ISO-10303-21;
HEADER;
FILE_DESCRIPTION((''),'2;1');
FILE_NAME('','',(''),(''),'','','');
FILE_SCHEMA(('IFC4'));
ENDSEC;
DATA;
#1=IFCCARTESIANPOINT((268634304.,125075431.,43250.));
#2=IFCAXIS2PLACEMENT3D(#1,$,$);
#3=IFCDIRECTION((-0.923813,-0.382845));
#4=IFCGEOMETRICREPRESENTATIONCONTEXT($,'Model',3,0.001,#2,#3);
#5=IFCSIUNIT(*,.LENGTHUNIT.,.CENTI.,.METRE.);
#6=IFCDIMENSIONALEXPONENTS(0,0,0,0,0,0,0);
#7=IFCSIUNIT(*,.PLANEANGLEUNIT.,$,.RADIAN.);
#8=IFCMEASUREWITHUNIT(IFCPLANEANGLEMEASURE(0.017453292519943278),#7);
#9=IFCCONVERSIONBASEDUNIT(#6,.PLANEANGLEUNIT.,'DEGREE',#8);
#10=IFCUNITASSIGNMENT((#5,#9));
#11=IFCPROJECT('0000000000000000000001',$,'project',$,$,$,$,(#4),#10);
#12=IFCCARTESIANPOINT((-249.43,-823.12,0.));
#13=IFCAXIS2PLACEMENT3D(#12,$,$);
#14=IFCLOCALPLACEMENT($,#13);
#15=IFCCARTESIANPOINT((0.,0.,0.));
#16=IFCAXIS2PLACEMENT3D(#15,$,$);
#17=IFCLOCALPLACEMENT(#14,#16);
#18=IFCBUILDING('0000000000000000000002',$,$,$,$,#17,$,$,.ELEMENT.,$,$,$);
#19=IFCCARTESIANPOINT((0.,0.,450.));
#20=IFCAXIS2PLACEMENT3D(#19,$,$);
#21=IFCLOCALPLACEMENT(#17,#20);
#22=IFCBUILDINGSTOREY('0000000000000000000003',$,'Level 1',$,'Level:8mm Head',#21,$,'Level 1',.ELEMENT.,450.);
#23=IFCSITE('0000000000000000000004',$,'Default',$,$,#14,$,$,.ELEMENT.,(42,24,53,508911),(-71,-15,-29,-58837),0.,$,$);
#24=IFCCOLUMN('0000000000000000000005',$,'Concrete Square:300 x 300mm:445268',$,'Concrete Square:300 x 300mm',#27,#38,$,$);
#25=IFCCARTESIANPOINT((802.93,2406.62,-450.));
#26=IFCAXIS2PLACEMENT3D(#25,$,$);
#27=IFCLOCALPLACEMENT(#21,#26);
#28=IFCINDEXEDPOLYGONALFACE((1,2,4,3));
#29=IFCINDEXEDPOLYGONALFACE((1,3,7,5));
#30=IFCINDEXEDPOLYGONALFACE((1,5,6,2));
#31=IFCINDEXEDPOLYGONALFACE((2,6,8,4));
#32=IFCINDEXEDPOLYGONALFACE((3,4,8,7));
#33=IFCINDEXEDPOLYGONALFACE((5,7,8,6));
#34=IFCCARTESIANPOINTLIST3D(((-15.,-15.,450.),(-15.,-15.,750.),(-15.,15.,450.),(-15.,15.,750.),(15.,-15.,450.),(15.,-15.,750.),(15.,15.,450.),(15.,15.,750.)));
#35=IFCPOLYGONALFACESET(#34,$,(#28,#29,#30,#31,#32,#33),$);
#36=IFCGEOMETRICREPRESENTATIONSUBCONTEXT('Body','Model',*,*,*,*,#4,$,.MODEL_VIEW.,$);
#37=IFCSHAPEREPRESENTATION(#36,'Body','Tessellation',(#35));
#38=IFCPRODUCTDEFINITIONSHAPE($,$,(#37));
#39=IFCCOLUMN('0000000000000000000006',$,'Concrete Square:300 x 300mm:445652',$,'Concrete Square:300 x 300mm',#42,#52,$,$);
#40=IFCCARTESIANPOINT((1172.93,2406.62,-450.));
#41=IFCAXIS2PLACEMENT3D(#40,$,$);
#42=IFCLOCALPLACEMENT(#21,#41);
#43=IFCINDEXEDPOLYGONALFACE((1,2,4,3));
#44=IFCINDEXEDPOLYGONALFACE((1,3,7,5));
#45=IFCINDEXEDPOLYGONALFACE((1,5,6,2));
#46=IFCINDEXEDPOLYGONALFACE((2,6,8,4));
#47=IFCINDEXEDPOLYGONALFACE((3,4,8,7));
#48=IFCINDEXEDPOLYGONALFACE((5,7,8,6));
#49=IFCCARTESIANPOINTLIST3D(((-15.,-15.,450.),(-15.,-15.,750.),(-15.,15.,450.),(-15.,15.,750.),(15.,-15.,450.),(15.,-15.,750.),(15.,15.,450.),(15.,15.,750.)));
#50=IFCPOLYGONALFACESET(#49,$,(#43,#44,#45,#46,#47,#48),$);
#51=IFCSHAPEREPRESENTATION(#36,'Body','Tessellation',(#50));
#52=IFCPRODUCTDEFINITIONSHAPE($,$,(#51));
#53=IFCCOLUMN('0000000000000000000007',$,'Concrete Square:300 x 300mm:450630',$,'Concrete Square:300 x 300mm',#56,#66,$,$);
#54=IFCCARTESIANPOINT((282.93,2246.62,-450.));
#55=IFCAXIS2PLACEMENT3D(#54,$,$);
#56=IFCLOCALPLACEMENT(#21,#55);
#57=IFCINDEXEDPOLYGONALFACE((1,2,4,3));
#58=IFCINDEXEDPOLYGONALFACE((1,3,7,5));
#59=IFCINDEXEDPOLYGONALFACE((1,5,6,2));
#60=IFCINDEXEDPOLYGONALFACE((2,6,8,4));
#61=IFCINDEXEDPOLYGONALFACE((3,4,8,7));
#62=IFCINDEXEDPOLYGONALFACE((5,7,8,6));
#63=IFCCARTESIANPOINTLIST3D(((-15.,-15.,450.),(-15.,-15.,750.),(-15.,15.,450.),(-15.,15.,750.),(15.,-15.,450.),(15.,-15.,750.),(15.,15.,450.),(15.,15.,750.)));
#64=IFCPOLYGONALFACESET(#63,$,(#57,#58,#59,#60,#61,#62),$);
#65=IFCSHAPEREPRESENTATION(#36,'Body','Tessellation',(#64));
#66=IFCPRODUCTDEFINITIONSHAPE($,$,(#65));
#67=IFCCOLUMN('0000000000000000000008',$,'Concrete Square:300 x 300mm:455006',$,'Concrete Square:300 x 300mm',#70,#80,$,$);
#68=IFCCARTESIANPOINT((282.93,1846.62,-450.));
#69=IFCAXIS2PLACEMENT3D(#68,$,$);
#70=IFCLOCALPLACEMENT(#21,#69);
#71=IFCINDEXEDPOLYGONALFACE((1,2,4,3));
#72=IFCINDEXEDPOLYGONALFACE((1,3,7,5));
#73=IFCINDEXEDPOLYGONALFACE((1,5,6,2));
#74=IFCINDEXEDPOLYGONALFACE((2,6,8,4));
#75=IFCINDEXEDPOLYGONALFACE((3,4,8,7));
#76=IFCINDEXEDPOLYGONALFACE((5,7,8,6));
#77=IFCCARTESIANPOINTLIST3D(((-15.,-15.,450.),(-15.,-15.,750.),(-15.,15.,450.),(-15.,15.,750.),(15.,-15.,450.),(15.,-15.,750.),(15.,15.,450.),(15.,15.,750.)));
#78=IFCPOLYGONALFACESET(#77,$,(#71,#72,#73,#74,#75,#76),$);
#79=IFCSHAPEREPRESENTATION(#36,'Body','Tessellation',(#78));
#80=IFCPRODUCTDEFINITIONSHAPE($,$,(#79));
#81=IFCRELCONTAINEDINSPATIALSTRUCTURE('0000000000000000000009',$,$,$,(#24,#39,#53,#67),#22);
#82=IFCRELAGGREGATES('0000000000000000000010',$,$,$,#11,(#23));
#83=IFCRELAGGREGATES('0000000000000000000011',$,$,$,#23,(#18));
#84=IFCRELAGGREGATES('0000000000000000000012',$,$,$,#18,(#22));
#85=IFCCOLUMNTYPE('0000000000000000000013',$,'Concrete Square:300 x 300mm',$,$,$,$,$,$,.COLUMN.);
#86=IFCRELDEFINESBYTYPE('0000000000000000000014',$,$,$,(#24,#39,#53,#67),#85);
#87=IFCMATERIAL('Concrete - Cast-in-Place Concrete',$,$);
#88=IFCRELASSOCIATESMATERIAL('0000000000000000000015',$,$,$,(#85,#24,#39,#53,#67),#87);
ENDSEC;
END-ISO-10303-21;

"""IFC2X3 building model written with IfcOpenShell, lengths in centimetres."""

from ifc_helpers import new_model, entity, si_unit, converted_unit, direction, frame, origin, origin_2d_with_axis, place, context, subcontext, project, spatial, rectangle, extrude, source, transform, mapped, material, type_object, type_shapes, element, save


model = new_model("IFC2X3")

# Units and contexts
model_context = context("Model", 3, precision=0.001, world=frame((268634304.0, 125075431.0, 43250.0)), true_north=direction((-0.923813, -0.382845)))
body_context = subcontext(model_context, "Body", "Model", "MODEL_VIEW")
ifc_project = project(units=[si_unit("LENGTHUNIT", "METRE", prefix="CENTI"), converted_unit("PLANEANGLEUNIT", "DEGREE", entity("IfcPlaneAngleMeasure", 0.017453292519943278), si_unit("PLANEANGLEUNIT", "RADIAN"), dimensions=[0, 0, 0, 0, 0, 0, 0])], contexts=[model_context])

# Site, building, storey
site_placement = place(None, frame((-249.43, -823.12, 0.0)))
site = spatial("IfcSite", under=ifc_project, at=site_placement, Name="Default", CompositionType="ELEMENT", RefLatitude=(42, 24, 53, 508911), RefLongitude=(-71, -15, -29, -58837), RefElevation=0.0)
building_placement = place(site_placement, origin())
building = spatial("IfcBuilding", under=site, at=building_placement, CompositionType="ELEMENT")
storey_placement = place(building_placement, frame((0.0, 0.0, 450.0)))
storey = spatial("IfcBuildingStorey", under=building, at=storey_placement, Name="Level 1", ObjectType="Level:8mm Head", LongName="Level 1", CompositionType="ELEMENT", Elevation=450.0)

# Columns
ifc_material_1 = material(Name="Concrete - Cast-in-Place Concrete")
column_type = type_object("IfcColumnType", Name="Concrete Square:300 x 300mm", PredefinedType="COLUMN", material=ifc_material_1)
shared_shape_1 = source(origin(), body_context, "Body", "SweptSolid", [
    extrude(rectangle(XDim=30.0, YDim=30.0, at=origin_2d_with_axis()), frame((0.0, 0.0, 450.0), z_axis=(0.0, 0.0, 1.0), x_axis=(-1.0, 0.0, 0.0)), (0.0, 0.0, 1.0), 300.0),
])
type_shapes(column_type, [shared_shape_1])
for number, where, name in (
    (1, (802.93, 2406.62, -450.0), "Concrete Square:300 x 300mm:445268"),
    (2, (1172.93, 2406.62, -450.0), "Concrete Square:300 x 300mm:445652"),
    (3, (282.93, 2246.62, -450.0), "Concrete Square:300 x 300mm:450630"),
    (4, (282.93, 1846.62, -450.0), "Concrete Square:300 x 300mm:455006"),
):
    element("IfcColumn", number, at=place(storey_placement, frame(where)), inside=storey, type_object=column_type, material=ifc_material_1, Name=name, ObjectType="Concrete Square:300 x 300mm", context=body_context, shape_type="MappedRepresentation", body=[
        mapped(shared_shape_1, transform((0.0, 0.0, 0.0), scale=1.0)),
    ])

save(model, "model.ifc")
